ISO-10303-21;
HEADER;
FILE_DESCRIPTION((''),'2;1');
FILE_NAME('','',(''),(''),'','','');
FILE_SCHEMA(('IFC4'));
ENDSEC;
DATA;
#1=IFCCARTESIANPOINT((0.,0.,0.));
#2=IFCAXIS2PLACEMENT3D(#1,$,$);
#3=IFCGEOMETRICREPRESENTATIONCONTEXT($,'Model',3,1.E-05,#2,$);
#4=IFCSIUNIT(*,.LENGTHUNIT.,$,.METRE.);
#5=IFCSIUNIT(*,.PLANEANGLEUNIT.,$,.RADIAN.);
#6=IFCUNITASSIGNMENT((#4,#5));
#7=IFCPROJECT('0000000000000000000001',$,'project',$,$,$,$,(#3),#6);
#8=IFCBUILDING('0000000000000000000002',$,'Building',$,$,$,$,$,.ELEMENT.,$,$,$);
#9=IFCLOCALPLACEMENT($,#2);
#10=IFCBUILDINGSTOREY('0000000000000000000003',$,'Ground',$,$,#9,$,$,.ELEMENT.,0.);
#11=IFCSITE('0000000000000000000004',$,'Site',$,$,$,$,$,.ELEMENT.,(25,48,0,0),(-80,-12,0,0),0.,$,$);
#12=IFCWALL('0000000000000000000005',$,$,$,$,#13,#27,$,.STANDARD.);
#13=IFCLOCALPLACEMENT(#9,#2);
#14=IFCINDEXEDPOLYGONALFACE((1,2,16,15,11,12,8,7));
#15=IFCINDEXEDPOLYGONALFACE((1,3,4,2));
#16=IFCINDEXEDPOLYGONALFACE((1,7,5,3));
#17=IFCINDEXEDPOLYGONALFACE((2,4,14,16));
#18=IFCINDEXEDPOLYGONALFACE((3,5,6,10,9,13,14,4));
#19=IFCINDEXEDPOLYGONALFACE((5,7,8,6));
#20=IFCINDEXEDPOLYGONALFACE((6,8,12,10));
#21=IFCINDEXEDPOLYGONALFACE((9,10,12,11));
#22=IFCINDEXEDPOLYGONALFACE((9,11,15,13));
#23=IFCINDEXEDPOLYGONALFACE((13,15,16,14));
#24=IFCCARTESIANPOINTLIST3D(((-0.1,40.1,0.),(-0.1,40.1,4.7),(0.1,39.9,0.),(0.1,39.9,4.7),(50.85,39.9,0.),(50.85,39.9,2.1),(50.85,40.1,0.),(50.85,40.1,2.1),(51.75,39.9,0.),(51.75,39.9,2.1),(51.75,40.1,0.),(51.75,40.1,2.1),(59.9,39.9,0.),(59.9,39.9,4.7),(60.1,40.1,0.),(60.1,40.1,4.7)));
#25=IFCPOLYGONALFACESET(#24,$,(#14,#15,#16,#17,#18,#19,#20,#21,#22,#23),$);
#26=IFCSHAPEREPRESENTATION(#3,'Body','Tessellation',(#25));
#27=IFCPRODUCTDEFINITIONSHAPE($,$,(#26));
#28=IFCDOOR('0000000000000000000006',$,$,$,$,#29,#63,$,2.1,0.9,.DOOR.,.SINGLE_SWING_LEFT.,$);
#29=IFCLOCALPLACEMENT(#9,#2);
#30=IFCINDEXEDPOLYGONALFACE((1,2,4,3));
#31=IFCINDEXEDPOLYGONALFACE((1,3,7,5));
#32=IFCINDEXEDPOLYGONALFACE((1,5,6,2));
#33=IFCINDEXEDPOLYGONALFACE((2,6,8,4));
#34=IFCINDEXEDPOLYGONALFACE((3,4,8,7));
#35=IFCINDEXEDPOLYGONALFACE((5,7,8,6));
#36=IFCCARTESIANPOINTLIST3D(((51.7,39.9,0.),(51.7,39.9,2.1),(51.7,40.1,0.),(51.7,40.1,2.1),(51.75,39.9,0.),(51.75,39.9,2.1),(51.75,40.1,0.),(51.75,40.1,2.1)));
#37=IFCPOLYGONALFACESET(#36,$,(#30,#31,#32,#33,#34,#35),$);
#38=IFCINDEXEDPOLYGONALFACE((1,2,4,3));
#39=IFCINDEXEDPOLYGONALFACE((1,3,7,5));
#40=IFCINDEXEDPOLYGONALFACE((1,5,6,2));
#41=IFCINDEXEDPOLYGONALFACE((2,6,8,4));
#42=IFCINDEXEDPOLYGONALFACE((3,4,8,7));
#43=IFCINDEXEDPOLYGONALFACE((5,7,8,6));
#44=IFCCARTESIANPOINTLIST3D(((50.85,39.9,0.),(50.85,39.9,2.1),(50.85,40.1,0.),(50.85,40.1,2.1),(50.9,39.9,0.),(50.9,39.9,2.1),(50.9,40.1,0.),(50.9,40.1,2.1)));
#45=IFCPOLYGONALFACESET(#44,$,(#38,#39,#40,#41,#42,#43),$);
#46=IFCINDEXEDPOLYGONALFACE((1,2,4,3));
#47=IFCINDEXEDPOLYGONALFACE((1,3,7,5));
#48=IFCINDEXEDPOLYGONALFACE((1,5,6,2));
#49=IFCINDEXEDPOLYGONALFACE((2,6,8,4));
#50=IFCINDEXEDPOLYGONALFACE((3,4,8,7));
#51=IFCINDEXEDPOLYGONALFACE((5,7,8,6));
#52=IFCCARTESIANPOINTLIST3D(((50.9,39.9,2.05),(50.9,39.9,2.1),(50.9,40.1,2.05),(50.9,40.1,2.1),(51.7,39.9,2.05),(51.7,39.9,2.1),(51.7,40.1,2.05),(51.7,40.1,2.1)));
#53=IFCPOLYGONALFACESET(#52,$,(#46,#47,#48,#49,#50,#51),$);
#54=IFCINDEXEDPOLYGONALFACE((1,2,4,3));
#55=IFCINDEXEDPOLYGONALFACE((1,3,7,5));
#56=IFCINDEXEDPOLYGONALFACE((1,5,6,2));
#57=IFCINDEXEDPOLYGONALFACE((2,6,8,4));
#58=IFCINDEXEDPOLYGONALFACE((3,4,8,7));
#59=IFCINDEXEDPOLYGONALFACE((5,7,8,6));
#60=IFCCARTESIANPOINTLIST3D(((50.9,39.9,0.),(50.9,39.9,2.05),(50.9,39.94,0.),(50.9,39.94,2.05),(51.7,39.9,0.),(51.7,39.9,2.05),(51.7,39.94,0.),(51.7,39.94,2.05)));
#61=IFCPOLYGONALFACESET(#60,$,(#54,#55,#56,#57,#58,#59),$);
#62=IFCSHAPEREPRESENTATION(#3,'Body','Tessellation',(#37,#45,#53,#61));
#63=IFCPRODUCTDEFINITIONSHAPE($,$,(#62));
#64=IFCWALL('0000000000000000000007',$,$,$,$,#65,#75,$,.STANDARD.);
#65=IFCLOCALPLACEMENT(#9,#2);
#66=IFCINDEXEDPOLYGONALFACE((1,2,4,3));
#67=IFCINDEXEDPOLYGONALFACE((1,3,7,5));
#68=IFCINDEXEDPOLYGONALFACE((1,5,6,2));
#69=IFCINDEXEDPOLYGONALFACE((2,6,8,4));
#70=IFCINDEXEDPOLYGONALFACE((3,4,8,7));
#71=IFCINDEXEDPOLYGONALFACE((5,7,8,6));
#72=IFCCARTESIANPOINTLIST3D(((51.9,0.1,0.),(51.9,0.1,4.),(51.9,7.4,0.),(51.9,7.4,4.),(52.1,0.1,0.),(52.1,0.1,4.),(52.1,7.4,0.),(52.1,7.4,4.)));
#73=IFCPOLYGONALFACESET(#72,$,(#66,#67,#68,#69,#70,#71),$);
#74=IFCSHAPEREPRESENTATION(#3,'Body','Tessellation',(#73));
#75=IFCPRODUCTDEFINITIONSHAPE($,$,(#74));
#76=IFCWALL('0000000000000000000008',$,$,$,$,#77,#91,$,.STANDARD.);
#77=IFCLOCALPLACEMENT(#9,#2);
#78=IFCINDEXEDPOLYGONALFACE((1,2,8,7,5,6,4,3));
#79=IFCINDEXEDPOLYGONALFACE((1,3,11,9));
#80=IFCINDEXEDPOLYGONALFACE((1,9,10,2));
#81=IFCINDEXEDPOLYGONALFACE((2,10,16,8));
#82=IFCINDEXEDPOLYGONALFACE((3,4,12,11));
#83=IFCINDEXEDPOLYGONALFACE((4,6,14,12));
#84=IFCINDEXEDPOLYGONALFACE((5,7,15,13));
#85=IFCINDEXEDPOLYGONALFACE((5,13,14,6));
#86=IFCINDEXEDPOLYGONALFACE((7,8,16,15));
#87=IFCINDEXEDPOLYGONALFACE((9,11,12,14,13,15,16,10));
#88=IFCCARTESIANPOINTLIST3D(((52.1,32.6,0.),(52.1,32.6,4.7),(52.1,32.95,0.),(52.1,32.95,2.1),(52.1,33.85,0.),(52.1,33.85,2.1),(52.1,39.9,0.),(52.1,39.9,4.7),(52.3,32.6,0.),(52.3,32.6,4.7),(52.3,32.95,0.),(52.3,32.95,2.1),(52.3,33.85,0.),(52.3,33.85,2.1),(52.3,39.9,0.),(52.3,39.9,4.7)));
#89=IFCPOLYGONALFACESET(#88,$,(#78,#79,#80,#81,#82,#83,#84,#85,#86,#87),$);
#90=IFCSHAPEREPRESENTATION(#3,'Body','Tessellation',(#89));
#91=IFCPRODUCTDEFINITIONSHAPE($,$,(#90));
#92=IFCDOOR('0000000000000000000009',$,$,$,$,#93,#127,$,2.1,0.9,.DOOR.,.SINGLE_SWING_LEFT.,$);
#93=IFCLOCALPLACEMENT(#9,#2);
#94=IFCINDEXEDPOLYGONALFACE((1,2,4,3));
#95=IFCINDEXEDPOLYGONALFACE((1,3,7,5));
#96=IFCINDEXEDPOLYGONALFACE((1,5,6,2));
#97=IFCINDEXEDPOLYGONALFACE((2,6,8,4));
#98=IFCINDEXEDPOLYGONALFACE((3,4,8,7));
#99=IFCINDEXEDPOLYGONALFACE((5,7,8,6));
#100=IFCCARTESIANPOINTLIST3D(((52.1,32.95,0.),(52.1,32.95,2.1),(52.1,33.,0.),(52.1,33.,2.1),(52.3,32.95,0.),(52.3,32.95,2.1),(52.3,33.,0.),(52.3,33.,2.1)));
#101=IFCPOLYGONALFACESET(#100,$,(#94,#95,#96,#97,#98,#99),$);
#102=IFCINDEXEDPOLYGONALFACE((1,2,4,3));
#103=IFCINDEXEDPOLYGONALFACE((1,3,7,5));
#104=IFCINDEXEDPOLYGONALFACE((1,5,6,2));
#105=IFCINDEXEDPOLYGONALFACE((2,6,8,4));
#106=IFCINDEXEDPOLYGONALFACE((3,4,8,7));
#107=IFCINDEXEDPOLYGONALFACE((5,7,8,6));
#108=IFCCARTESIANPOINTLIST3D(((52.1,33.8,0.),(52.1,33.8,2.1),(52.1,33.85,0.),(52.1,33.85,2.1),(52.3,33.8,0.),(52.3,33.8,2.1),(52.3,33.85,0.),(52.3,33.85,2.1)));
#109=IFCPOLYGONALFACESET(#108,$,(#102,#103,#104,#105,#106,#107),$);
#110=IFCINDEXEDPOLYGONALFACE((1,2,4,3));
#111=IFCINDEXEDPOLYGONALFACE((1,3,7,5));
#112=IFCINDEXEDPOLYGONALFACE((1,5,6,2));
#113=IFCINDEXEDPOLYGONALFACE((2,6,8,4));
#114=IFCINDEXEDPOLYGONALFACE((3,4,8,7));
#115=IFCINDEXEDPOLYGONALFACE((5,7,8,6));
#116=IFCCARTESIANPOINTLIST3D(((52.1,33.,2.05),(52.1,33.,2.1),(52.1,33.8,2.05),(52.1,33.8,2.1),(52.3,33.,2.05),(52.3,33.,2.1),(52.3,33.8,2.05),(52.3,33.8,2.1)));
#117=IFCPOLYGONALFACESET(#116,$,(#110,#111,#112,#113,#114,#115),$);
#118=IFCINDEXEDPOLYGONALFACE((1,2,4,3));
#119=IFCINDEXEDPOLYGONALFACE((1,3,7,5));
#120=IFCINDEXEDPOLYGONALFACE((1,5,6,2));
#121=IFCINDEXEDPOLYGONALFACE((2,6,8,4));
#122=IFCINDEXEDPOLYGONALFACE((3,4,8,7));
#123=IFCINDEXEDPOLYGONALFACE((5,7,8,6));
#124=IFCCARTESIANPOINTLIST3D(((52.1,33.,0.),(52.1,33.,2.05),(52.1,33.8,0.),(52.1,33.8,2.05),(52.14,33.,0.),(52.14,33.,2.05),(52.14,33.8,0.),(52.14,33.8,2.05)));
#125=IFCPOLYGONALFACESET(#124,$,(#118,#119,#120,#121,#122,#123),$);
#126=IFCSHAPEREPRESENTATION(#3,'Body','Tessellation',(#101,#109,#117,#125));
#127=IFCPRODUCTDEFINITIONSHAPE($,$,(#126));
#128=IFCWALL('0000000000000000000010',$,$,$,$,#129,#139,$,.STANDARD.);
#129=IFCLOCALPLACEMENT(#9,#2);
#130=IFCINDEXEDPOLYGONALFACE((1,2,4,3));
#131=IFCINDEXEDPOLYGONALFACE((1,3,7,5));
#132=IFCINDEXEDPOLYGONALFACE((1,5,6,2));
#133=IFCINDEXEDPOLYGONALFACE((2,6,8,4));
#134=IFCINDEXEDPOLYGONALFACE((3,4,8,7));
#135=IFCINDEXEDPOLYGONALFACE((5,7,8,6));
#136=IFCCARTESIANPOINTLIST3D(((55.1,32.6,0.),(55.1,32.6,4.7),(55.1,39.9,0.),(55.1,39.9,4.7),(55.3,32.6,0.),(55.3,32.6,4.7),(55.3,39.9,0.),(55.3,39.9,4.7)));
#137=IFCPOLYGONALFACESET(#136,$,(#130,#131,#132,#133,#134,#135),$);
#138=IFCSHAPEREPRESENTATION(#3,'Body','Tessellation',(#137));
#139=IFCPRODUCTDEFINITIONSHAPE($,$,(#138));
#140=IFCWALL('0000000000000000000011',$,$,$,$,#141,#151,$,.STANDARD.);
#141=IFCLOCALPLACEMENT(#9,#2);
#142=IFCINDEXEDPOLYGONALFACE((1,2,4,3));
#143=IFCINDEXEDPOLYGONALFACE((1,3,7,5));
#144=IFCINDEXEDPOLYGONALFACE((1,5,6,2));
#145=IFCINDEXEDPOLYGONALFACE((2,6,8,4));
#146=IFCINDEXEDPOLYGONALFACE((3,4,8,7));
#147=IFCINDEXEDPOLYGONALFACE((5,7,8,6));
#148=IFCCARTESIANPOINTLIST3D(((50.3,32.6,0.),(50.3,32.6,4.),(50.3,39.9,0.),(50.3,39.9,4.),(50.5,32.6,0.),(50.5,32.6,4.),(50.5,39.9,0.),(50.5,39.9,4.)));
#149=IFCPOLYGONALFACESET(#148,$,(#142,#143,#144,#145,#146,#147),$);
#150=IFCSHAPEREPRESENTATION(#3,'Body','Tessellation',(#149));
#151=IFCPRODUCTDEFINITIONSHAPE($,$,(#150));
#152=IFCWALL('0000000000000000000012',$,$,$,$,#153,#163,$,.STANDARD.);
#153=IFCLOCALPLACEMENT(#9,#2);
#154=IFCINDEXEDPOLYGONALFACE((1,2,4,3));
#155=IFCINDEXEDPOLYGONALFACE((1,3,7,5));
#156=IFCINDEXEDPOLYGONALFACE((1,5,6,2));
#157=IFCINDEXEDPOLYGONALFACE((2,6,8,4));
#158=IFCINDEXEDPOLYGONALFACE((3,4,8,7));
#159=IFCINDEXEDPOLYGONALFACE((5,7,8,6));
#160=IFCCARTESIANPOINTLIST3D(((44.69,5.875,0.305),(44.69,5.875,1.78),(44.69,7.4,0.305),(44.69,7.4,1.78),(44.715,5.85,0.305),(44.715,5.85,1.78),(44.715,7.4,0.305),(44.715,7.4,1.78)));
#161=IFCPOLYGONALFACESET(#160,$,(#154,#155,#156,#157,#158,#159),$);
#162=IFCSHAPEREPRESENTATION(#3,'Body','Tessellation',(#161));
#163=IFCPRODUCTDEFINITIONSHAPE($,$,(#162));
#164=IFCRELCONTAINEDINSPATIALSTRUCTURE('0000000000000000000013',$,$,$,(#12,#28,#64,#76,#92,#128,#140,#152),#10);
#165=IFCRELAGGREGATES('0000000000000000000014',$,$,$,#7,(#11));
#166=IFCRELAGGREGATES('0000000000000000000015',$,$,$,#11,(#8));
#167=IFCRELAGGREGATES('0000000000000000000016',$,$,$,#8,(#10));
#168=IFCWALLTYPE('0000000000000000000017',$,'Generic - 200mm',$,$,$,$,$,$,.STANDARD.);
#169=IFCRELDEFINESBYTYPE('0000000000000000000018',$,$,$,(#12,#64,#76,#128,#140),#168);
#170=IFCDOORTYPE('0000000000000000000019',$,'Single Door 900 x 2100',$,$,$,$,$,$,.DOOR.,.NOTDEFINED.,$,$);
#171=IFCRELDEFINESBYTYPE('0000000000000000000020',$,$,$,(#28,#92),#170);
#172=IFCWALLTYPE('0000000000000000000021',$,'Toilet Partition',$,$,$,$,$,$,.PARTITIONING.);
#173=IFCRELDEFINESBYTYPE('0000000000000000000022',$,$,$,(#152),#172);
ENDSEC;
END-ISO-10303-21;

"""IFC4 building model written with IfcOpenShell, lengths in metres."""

from ifc_helpers import new_model, si_unit, frame, frame_2d, origin, origin_with_axes, origin_2d, place, context, project, spatial, polyline, rectangle, outline, extrude, type_object, element, fill, save


model = new_model("IFC4")

# Units and contexts
model_context = context("Model", 3, precision=1e-05, world=origin())
ifc_project = project(units=[si_unit("LENGTHUNIT", "METRE"), si_unit("PLANEANGLEUNIT", "RADIAN")], contexts=[model_context])

# Site, building, storey
site = spatial("IfcSite", under=ifc_project, Name="Site", CompositionType="ELEMENT", RefLatitude=(25, 48, 0, 0), RefLongitude=(-80, -12, 0, 0), RefElevation=0.0)
building = spatial("IfcBuilding", under=site, Name="Building", CompositionType="ELEMENT")
storey_placement = place(None, origin())
storey = spatial("IfcBuildingStorey", under=building, at=storey_placement, Name="Ground", CompositionType="ELEMENT", Elevation=0.0)

# Shared definitions
wall_type_1 = type_object("IfcWallType", Name="Generic - 200mm", PredefinedType="STANDARD")

# Wall, opening, door
wall_1_placement = place(None, frame((60.0, 40.0, 0.0), z_axis=(0.0, 0.0, 1.0), x_axis=(-1.0, 0.0, 0.0)))
wall_1 = element("IfcWall", 1, at=wall_1_placement, inside=storey, type_object=wall_type_1, PredefinedType="STANDARD", context=model_context, shape_type="SweptSolid", body=[
    extrude(outline(polyline([(-0.1, -0.1), (60.1, -0.1), (59.9, 0.1), (0.1, 0.1), (-0.1, -0.1)])), origin(), (0.0, 0.0, 1.0), 4.7),
])
opening_1_placement = place(wall_1_placement, frame((8.7, 0.0, 0.0), z_axis=(0.0, 0.0, 1.0), x_axis=(1.0, 0.0, 0.0)))
opening_1 = element("IfcOpeningElement", 2, at=opening_1_placement, cuts=wall_1, PredefinedType="OPENING", context=model_context, shape_type="SweptSolid", body=[
    extrude(rectangle(XDim=0.9, YDim=0.202, at=origin_2d()), origin(), (0.0, 0.0, 1.0), 2.1),
])
door_type = type_object("IfcDoorType", Name="Single Door 900 x 2100", OperationType="NOTDEFINED", PredefinedType="DOOR")
door_1_placement = place(opening_1_placement, origin_with_axes())
door_1 = element("IfcDoor", 3, at=door_1_placement, inside=storey, type_object=door_type, OperationType="SINGLE_SWING_LEFT", OverallHeight=2.1, OverallWidth=0.9, PredefinedType="DOOR", context=model_context, shape_type="SweptSolid", body=[
    extrude(rectangle(XDim=0.05, YDim=0.2, at=frame_2d((-0.425, 0.0))), origin(), (0.0, 0.0, 1.0), 2.1),
    extrude(rectangle(XDim=0.05, YDim=0.2, at=frame_2d((0.425, 0.0))), origin(), (0.0, 0.0, 1.0), 2.1),
    extrude(rectangle(XDim=0.8, YDim=0.2, at=origin_2d()), frame((0.0, 0.0, 2.05)), (0.0, 0.0, 1.0), 0.05),
    extrude(rectangle(XDim=0.8, YDim=0.04, at=frame_2d((0.0, 0.08))), origin(), (0.0, 0.0, 1.0), 2.05),
])
fill(opening_1, door_1)

# Wall
wall_2_placement = place(None, frame((52.0, 0.0, 0.0), z_axis=(0.0, 0.0, 1.0), x_axis=(0.0, 1.0, 0.0)))
element("IfcWall", 4, at=wall_2_placement, inside=storey, type_object=wall_type_1, PredefinedType="STANDARD", context=model_context, shape_type="SweptSolid", body=[
    extrude(outline(polyline([(0.1, -0.1), (7.4, -0.1), (7.4, 0.1), (0.1, 0.1), (0.1, -0.1)])), origin(), (0.0, 0.0, 1.0), 4.0),
])

# Wall, opening, door
wall_3_placement = place(None, frame((52.2, 32.5, 0.0), z_axis=(0.0, 0.0, 1.0), x_axis=(0.0, 1.0, 0.0)))
wall_3 = element("IfcWall", 5, at=wall_3_placement, inside=storey, type_object=wall_type_1, PredefinedType="STANDARD", context=model_context, shape_type="SweptSolid", body=[
    extrude(outline(polyline([(0.1, -0.1), (7.4, -0.1), (7.4, 0.1), (0.1, 0.1), (0.1, -0.1)])), origin(), (0.0, 0.0, 1.0), 4.7),
])
opening_2_placement = place(wall_3_placement, frame((0.9, 0.0, 0.0), z_axis=(0.0, 0.0, 1.0), x_axis=(1.0, 0.0, 0.0)))
opening_2 = element("IfcOpeningElement", 6, at=opening_2_placement, cuts=wall_3, PredefinedType="OPENING", context=model_context, shape_type="SweptSolid", body=[
    extrude(rectangle(XDim=0.9, YDim=0.202, at=origin_2d()), origin(), (0.0, 0.0, 1.0), 2.1),
])
door_2_placement = place(opening_2_placement, origin_with_axes())
door_2 = element("IfcDoor", 7, at=door_2_placement, inside=storey, type_object=door_type, OperationType="SINGLE_SWING_LEFT", OverallHeight=2.1, OverallWidth=0.9, PredefinedType="DOOR", context=model_context, shape_type="SweptSolid", body=[
    extrude(rectangle(XDim=0.05, YDim=0.2, at=frame_2d((-0.425, 0.0))), origin(), (0.0, 0.0, 1.0), 2.1),
    extrude(rectangle(XDim=0.05, YDim=0.2, at=frame_2d((0.425, 0.0))), origin(), (0.0, 0.0, 1.0), 2.1),
    extrude(rectangle(XDim=0.8, YDim=0.2, at=origin_2d()), frame((0.0, 0.0, 2.05)), (0.0, 0.0, 1.0), 0.05),
    extrude(rectangle(XDim=0.8, YDim=0.04, at=frame_2d((0.0, 0.08))), origin(), (0.0, 0.0, 1.0), 2.05),
])
fill(opening_2, door_2)

# Walls
wall_4_placement = place(None, frame((55.2, 32.5, 0.0), z_axis=(0.0, 0.0, 1.0), x_axis=(0.0, 1.0, 0.0)))
element("IfcWall", 8, at=wall_4_placement, inside=storey, type_object=wall_type_1, PredefinedType="STANDARD", context=model_context, shape_type="SweptSolid", body=[
    extrude(outline(polyline([(0.1, -0.1), (7.4, -0.1), (7.4, 0.1), (0.1, 0.1), (0.1, -0.1)])), origin(), (0.0, 0.0, 1.0), 4.7),
])
wall_5_placement = place(None, frame((50.4, 32.5, 0.0), z_axis=(0.0, 0.0, 1.0), x_axis=(0.0, 1.0, 0.0)))
element("IfcWall", 9, at=wall_5_placement, inside=storey, type_object=wall_type_1, PredefinedType="STANDARD", context=model_context, shape_type="SweptSolid", body=[
    extrude(outline(polyline([(0.1, -0.1), (7.4, -0.1), (7.4, 0.1), (0.1, 0.1), (0.1, -0.1)])), origin(), (0.0, 0.0, 1.0), 4.0),
])
wall_type_2 = type_object("IfcWallType", Name="Toilet Partition", PredefinedType="PARTITIONING")
wall_6_placement = place(None, frame((44.7025, 7.4, 0.305), z_axis=(0.0, 0.0, 1.0), x_axis=(0.0, -1.0, 0.0)))
element("IfcWall", 10, at=wall_6_placement, inside=storey, type_object=wall_type_2, PredefinedType="STANDARD", context=model_context, shape_type="SweptSolid", body=[
    extrude(outline(polyline([(0.0, -0.0125), (1.525, -0.0125), (1.55, 0.0125), (0.0, 0.0125), (0.0, -0.0125)])), origin(), (0.0, 0.0, 1.0), 1.475),
])

save(model, "model.ifc")
